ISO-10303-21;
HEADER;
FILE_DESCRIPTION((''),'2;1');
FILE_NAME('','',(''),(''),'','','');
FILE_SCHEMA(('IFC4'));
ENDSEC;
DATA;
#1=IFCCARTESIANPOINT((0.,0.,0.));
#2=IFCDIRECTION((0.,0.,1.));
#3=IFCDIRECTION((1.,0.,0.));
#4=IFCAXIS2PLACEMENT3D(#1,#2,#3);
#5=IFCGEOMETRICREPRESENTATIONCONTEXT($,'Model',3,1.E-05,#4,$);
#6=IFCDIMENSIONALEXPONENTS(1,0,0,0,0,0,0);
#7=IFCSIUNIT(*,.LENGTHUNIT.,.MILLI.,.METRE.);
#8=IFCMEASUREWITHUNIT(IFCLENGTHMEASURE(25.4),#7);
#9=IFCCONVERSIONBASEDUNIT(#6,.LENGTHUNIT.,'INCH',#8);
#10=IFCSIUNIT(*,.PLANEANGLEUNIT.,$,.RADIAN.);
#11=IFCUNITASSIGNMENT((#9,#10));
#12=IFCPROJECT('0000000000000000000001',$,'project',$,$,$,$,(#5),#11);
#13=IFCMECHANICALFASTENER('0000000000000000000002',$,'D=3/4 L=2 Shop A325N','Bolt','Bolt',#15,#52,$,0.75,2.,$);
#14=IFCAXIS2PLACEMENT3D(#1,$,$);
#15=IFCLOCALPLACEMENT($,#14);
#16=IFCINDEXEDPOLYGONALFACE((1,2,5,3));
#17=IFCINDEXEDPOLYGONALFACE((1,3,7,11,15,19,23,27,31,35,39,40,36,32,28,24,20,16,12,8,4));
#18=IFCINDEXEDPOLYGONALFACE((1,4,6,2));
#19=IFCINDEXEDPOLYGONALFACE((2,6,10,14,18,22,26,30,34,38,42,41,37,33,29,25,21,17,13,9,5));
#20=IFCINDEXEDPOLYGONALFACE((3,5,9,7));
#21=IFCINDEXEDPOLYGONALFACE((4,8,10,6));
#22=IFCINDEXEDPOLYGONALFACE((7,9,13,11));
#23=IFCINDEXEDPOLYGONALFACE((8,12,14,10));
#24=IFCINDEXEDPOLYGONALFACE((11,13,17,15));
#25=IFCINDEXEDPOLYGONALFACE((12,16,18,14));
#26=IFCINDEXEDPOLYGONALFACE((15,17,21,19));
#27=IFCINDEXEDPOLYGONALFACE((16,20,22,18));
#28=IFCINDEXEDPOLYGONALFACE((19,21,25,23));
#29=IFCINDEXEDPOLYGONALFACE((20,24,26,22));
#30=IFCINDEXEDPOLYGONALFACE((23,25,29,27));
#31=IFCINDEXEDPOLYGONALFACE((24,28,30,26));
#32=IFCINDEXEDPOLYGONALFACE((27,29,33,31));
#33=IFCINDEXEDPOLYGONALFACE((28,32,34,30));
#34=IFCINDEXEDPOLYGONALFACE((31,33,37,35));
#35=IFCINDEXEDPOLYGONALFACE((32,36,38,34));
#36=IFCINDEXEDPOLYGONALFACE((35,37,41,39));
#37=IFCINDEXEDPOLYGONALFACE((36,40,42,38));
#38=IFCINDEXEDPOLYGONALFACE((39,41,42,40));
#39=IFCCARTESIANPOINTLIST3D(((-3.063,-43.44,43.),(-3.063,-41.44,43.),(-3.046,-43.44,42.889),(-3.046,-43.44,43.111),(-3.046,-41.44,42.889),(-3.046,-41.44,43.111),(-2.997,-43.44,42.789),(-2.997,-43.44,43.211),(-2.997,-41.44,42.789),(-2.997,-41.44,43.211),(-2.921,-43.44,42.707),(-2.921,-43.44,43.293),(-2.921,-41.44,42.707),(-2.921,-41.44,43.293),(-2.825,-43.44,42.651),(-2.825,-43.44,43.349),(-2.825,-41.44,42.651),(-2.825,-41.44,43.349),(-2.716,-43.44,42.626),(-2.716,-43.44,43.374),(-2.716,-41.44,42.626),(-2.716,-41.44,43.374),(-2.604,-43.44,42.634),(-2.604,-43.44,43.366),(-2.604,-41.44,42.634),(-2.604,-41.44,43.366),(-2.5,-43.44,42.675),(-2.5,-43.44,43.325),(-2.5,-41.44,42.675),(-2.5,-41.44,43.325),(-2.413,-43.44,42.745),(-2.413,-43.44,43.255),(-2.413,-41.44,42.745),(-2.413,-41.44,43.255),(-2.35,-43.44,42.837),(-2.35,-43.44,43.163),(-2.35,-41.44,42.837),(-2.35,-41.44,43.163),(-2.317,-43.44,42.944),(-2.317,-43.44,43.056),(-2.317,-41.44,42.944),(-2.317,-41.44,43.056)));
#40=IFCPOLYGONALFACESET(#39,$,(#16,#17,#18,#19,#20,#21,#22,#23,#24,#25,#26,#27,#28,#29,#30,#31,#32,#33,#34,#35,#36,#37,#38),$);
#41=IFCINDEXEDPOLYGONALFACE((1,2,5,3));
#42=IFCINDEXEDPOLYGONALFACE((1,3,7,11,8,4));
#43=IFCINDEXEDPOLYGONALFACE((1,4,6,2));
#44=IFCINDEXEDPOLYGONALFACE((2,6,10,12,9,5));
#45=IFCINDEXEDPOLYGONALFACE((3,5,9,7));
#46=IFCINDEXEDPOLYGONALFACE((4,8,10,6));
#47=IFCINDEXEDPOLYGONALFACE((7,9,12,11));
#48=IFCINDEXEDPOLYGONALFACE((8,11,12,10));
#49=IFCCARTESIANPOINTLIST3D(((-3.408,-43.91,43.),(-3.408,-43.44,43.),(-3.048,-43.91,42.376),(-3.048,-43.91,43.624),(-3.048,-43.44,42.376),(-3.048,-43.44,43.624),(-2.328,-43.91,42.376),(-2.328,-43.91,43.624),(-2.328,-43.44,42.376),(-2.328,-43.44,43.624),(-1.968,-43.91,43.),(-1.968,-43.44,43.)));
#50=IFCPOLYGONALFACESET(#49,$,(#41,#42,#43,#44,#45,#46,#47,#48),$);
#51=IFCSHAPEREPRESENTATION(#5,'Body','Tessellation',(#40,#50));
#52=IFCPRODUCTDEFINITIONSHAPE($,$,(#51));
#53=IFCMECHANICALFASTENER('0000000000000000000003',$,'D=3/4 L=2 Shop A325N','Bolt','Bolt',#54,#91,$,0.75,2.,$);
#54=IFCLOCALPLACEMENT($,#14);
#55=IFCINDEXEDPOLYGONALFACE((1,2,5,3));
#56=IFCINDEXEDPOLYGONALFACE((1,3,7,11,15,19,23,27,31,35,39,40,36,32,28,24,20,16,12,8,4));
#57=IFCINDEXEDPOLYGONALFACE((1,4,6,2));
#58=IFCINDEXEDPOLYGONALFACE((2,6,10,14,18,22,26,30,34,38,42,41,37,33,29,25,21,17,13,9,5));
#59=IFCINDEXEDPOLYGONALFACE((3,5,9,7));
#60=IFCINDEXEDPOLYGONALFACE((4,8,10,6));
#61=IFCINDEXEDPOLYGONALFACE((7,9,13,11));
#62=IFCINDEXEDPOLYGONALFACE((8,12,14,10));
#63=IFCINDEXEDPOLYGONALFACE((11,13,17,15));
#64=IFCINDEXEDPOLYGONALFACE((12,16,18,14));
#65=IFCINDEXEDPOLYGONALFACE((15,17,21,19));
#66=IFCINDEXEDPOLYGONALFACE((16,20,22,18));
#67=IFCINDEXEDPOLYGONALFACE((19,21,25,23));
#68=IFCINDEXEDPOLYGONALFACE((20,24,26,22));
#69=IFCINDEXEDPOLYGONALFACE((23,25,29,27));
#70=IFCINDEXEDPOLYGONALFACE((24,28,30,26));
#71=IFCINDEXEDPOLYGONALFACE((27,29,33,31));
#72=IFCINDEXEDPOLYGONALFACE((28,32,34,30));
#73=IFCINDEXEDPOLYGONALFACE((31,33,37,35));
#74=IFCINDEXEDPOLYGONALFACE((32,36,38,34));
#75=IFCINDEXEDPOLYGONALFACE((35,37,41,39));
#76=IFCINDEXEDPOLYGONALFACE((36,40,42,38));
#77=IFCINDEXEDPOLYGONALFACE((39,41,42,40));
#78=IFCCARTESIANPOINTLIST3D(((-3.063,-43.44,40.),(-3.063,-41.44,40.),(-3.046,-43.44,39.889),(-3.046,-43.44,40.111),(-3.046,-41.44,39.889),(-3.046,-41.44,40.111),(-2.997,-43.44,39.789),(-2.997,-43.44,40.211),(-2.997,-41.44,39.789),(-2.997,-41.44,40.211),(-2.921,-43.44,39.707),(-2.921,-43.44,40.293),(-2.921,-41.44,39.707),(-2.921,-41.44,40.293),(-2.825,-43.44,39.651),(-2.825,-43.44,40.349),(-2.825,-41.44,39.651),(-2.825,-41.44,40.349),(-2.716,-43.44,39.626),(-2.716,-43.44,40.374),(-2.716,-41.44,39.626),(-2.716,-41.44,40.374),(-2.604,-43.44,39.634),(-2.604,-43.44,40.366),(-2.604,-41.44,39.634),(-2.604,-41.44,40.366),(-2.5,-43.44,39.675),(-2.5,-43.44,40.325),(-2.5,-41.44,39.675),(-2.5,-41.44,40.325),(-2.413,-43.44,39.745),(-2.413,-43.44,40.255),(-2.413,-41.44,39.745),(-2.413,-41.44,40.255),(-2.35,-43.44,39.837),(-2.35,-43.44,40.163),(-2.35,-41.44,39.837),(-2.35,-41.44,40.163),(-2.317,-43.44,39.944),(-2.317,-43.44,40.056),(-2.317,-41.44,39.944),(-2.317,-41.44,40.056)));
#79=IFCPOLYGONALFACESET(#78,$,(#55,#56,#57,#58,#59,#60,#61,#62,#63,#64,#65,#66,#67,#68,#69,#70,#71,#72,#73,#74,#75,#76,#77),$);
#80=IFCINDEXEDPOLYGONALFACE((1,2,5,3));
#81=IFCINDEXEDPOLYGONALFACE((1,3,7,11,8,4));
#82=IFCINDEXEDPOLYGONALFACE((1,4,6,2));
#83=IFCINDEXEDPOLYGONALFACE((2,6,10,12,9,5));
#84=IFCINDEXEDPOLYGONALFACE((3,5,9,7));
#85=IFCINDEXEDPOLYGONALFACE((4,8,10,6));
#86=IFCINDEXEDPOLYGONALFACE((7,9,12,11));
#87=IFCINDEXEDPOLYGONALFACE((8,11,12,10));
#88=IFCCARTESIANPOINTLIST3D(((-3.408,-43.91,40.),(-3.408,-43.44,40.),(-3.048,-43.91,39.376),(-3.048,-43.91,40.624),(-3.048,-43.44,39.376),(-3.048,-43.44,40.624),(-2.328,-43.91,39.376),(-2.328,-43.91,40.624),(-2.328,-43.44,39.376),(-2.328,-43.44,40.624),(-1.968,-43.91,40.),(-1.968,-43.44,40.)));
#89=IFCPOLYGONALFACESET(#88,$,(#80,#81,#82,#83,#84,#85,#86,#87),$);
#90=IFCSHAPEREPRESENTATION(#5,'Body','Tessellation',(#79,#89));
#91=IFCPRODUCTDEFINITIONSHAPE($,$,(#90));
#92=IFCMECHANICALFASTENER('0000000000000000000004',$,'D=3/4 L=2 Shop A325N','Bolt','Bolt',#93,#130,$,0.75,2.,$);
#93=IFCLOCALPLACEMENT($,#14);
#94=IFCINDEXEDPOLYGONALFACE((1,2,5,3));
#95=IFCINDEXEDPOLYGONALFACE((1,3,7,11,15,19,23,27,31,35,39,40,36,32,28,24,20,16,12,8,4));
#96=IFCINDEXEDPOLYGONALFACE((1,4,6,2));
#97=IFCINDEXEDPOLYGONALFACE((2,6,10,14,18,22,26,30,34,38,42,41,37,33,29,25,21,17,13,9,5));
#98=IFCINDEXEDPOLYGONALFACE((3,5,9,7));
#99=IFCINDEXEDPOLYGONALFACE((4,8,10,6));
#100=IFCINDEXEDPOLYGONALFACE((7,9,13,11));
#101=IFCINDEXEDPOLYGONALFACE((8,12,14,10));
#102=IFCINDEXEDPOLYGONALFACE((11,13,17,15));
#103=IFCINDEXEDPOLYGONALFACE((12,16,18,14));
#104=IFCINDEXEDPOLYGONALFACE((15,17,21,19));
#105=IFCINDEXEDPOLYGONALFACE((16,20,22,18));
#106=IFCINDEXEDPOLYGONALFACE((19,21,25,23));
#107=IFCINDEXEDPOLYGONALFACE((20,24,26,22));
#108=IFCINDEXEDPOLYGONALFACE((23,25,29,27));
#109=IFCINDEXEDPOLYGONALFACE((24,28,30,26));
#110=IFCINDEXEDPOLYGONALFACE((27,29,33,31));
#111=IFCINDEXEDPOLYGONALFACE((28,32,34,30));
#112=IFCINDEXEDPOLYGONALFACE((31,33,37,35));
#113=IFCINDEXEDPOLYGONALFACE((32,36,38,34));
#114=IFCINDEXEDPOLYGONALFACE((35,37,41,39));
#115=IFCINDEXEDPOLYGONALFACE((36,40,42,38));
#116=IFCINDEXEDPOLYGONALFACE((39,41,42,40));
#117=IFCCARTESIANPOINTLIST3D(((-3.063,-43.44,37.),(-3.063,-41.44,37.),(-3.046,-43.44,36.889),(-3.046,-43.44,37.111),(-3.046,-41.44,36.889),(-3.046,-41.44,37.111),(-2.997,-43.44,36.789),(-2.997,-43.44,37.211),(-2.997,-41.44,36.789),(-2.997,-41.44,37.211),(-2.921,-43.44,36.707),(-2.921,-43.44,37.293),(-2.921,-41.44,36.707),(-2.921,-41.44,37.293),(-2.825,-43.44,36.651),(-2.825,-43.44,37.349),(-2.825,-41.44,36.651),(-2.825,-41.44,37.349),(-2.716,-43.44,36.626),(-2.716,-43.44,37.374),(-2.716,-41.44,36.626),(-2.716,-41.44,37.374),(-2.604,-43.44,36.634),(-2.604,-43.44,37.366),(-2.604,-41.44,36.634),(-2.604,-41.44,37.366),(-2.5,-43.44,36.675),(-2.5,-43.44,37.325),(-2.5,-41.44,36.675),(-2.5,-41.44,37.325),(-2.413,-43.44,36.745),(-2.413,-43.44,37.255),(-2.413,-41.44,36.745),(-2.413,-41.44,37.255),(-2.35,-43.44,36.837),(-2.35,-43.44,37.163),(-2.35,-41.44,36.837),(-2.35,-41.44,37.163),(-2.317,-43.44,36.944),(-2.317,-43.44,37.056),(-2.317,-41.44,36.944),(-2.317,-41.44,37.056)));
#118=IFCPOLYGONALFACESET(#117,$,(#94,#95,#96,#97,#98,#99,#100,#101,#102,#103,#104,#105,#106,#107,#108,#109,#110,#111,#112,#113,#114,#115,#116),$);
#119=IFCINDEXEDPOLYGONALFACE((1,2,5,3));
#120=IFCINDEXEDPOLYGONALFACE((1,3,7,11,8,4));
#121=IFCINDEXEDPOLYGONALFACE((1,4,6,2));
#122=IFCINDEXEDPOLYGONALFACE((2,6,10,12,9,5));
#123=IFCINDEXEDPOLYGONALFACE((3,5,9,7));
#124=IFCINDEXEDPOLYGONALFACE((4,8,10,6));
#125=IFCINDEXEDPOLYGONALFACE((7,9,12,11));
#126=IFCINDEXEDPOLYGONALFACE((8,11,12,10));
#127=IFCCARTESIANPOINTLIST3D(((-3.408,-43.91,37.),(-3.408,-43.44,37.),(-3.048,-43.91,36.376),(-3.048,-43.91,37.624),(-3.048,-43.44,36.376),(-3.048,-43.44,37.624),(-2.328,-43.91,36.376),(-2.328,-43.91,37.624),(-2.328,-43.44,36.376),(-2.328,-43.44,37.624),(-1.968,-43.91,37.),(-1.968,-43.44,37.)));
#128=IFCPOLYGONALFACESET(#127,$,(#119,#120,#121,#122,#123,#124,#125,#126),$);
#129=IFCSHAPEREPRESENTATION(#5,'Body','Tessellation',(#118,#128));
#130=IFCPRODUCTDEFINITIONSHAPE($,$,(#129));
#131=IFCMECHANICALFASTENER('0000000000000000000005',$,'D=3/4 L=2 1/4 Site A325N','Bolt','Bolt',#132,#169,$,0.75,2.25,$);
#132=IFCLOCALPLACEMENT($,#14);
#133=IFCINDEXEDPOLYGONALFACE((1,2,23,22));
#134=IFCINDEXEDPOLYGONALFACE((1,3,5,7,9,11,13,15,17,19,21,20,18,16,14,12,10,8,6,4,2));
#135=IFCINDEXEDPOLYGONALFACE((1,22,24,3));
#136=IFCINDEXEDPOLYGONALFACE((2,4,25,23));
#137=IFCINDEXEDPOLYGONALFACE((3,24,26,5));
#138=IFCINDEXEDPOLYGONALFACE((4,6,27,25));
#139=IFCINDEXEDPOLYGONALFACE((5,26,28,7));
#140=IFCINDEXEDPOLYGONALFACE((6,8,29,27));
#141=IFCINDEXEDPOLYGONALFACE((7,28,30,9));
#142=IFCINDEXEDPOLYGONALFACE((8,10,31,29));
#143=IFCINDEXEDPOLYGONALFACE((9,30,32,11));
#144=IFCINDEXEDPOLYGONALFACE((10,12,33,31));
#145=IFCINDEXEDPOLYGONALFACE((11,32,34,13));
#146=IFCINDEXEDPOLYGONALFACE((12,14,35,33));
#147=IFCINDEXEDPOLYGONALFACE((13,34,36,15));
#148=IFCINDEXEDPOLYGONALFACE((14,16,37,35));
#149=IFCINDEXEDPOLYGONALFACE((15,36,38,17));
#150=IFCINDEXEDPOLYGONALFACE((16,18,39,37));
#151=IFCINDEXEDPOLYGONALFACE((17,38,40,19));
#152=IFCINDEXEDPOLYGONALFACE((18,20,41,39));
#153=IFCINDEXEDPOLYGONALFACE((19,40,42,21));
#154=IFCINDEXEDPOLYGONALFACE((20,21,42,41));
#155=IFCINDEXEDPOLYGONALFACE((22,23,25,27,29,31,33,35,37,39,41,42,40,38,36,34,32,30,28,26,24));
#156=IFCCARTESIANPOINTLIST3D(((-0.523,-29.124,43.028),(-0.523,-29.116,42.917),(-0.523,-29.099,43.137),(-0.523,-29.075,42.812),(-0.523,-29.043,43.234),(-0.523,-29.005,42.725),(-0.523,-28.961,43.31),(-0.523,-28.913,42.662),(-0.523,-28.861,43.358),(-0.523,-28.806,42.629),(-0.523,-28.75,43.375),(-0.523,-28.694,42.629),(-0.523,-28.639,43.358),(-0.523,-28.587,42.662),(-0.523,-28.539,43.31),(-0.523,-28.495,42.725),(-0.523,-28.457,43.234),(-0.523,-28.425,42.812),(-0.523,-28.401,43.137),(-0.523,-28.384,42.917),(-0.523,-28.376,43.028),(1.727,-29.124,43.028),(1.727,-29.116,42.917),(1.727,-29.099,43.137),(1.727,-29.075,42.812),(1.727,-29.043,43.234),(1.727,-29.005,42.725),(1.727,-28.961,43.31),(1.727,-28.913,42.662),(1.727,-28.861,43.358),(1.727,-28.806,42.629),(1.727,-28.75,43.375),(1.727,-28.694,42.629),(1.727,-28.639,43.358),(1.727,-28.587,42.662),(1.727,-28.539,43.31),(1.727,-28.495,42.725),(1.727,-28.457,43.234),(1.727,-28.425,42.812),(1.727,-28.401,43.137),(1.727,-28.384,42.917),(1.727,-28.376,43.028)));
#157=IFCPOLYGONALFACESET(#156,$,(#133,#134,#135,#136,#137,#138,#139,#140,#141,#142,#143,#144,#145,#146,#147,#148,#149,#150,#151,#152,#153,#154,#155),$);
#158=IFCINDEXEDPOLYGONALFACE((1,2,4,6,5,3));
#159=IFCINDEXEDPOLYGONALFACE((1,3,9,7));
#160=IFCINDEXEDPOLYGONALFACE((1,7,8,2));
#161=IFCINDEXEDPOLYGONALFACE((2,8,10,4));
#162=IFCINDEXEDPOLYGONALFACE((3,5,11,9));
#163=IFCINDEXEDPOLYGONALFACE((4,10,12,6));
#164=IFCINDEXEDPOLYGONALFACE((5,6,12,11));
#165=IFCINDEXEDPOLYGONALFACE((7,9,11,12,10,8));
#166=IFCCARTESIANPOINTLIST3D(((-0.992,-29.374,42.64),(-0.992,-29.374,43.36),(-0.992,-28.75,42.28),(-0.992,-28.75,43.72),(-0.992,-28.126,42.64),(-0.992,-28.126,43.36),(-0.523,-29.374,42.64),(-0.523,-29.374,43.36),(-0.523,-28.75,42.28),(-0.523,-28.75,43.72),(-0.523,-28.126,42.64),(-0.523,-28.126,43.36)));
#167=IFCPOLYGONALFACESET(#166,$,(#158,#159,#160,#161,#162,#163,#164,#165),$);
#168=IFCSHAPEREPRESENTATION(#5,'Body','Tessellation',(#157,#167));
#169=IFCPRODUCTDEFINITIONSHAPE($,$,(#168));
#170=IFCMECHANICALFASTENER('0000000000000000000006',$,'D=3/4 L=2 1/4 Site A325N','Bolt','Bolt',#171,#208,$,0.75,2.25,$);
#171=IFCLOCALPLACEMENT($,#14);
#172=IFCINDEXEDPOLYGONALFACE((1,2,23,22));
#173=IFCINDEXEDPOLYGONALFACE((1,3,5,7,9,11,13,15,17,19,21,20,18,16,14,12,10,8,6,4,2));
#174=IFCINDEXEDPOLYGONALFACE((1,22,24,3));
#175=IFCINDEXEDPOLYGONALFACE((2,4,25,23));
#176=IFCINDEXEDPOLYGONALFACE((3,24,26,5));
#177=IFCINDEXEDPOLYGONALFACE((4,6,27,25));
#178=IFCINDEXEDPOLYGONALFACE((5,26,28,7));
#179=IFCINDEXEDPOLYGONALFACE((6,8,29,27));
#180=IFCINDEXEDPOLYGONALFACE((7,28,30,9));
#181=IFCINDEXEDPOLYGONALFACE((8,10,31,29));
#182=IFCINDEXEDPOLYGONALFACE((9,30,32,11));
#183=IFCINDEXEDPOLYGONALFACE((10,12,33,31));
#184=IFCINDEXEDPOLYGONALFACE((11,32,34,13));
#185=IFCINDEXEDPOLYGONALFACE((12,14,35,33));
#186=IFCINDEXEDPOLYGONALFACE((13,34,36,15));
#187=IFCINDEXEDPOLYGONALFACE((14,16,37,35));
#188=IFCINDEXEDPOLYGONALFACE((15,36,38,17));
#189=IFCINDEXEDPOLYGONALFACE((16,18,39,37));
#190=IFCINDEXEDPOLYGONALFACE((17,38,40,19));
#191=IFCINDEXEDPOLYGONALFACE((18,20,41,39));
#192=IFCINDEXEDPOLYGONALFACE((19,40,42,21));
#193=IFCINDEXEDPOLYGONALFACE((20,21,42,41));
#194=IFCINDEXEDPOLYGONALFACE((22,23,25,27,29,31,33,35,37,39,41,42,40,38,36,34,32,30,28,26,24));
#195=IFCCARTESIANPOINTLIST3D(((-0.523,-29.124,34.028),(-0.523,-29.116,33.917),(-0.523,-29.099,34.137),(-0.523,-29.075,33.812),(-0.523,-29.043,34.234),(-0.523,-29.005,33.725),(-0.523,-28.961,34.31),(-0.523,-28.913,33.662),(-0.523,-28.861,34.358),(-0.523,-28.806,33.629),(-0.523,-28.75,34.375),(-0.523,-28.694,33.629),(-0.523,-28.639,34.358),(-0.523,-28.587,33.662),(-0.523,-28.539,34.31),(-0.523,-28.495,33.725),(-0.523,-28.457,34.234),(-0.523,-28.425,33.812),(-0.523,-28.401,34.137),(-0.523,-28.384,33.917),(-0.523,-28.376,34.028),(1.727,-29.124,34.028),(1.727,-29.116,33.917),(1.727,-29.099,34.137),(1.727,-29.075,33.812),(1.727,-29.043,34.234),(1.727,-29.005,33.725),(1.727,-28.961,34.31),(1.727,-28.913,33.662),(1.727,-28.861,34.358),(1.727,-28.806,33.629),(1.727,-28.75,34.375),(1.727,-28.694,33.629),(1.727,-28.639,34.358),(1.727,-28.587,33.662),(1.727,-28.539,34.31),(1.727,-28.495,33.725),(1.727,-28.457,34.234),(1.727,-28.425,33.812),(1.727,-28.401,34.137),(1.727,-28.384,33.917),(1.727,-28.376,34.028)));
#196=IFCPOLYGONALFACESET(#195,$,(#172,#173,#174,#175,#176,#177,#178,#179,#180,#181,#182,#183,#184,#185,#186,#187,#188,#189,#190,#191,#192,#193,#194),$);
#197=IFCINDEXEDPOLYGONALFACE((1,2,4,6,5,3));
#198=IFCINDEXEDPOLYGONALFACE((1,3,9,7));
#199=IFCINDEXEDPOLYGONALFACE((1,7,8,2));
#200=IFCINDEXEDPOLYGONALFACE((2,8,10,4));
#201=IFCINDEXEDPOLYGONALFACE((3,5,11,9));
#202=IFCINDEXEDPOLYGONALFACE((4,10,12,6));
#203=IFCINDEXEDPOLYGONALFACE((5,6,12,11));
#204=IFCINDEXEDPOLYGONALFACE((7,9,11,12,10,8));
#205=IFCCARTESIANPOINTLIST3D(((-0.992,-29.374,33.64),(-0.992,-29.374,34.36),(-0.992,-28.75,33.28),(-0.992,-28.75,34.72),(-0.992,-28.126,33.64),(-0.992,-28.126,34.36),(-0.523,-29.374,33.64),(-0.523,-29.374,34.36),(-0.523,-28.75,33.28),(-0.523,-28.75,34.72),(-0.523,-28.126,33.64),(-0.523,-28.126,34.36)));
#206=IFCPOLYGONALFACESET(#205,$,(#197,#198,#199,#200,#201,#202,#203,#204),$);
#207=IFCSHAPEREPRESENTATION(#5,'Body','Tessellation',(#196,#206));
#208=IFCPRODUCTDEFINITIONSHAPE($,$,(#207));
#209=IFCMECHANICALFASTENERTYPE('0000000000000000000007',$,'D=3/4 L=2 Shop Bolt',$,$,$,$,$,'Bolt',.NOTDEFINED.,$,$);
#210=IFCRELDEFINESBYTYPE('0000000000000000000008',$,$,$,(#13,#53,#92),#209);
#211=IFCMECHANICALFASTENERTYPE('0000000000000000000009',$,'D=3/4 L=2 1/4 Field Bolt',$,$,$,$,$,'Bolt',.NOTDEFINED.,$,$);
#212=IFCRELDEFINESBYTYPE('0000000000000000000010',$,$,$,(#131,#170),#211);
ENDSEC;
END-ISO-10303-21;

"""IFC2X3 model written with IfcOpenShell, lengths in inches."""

from ifc_helpers import new_model, entity, si_unit, converted_unit, frame, origin_with_axes, origin_2d_with_axis, place, context, project, polyline, circle, outline, extrude, source, transform, mapped, type_object, type_shapes, element, save


model = new_model("IFC2X3")

# Units and contexts
model_context = context("Model", 3, precision=1e-05, world=origin_with_axes())
ifc_project = project(units=[converted_unit("LENGTHUNIT", "INCH", entity("IfcLengthMeasure", 25.4), si_unit("LENGTHUNIT", "METRE", prefix="MILLI"), dimensions=[1, 0, 0, 0, 0, 0, 0]), si_unit("PLANEANGLEUNIT", "RADIAN")], contexts=[model_context])

# Mechanical fasteners
mechanical_fastener_type_1 = type_object("IfcMechanicalFastenerType", Name="D=3/4 L=2 Shop Bolt", ElementType="Bolt")
shared_shape_1 = source(origin_with_axes(), model_context, "Body", "SweptSolid", [
    extrude(circle(Radius=0.375, at=origin_2d_with_axis()), frame((0.0, 0.0, 0.0), z_axis=(1.0, 0.0, 0.0), x_axis=(0.0, 1.0, 0.0)), (0.0, 0.0, 1.0), 2.0),
    extrude(outline(polyline([(-0.72, 0.0), (-0.36, 0.624), (0.36, 0.624), (0.72, 0.0), (0.36, -0.624), (-0.36, -0.624), (-0.72, 0.0)])), frame((0.0, 0.0, 0.0), z_axis=(1.0, 0.0, 0.0), x_axis=(0.0, 1.0, 0.0)), (0.0, 0.0, -1.0), 0.47),
])
type_shapes(mechanical_fastener_type_1, [shared_shape_1])
placement_1 = place(None, origin_with_axes())
placement_2 = place(placement_1, origin_with_axes())
placement_3 = place(placement_2, frame((0.0, -43.0, 46.0), z_axis=(0.0, 0.0, 1.0), x_axis=(-1.0, 0.0, 0.0)))
placement_4 = place(placement_3, frame((2.688, 0.44, -9.0), z_axis=(0.0, 0.0, 1.0), x_axis=(0.0, -1.0, 0.0)))
for number, where, z_axis, x_axis, name in (
    (1, (0.0, 0.0, 6.0), (0.0, 0.0, 1.0), (1.0, 0.0, 0.0), "D=3/4 L=2 Shop A325N"),
    (2, (0.0, 0.0, 3.0), (0.0, 0.0, 1.0), (1.0, 0.0, 0.0), "D=3/4 L=2 Shop A325N"),
    (3, (0.0, 0.0, 0.0), (0.0, 0.0, 1.0), (1.0, 0.0, 0.0), "D=3/4 L=2 Shop A325N"),
):
    element("IfcMechanicalFastener", number, at=place(placement_4, frame(where, z_axis=z_axis, x_axis=x_axis)), type_object=mechanical_fastener_type_1, Name=name, Description="Bolt", ObjectType="Bolt", NominalDiameter=0.75, NominalLength=2.0, context=model_context, shape_type="MappedRepresentation", body=[
        mapped(shared_shape_1, transform((0.0, 0.0, 0.0), scale=1.0)),
    ])
mechanical_fastener_type_2 = type_object("IfcMechanicalFastenerType", Name="D=3/4 L=2 1/4 Field Bolt", ElementType="Bolt")
shared_shape_2 = source(origin_with_axes(), model_context, "Body", "SweptSolid", [
    extrude(circle(Radius=0.375, at=origin_2d_with_axis()), frame((0.0, 0.0, 0.0), z_axis=(1.0, 0.0, 0.0), x_axis=(0.0, 1.0, 0.0)), (0.0, 0.0, 1.0), 2.25),
    extrude(outline(polyline([(-0.72, 0.0), (-0.36, 0.624), (0.36, 0.624), (0.72, 0.0), (0.36, -0.624), (-0.36, -0.624), (-0.72, 0.0)])), frame((0.0, 0.0, 0.0), z_axis=(1.0, 0.0, 0.0), x_axis=(0.0, 1.0, 0.0)), (0.0, 0.0, -1.0), 0.47),
])
type_shapes(mechanical_fastener_type_2, [shared_shape_2])
placement_5 = place(placement_2, frame((0.0, -27.0, 46.0), z_axis=(0.0, 0.0, 1.0), x_axis=(0.0, -1.0, 0.0)))
placement_6 = place(placement_5, frame((1.75, -0.523, -3.0), z_axis=(1.0, 0.0, 0.0), x_axis=(0.0, 1.0, 0.0)))
for number, where, z_axis, x_axis, name in (
    (4, (0.0, 0.0, 0.0), (0.0, 0.0, 1.0), (1.0, 0.0, 0.0), "D=3/4 L=2 1/4 Site A325N"),
    (5, (0.0, -9.0, 0.0), (0.0, 0.0, 1.0), (1.0, 0.0, 0.0), "D=3/4 L=2 1/4 Site A325N"),
):
    element("IfcMechanicalFastener", number, at=place(placement_6, frame(where, z_axis=z_axis, x_axis=x_axis)), type_object=mechanical_fastener_type_2, Name=name, Description="Bolt", ObjectType="Bolt", NominalDiameter=0.75, NominalLength=2.25, context=model_context, shape_type="MappedRepresentation", body=[
        mapped(shared_shape_2, transform((0.0, 0.0, 0.0), scale=1.0)),
    ])

save(model, "model.ifc")
